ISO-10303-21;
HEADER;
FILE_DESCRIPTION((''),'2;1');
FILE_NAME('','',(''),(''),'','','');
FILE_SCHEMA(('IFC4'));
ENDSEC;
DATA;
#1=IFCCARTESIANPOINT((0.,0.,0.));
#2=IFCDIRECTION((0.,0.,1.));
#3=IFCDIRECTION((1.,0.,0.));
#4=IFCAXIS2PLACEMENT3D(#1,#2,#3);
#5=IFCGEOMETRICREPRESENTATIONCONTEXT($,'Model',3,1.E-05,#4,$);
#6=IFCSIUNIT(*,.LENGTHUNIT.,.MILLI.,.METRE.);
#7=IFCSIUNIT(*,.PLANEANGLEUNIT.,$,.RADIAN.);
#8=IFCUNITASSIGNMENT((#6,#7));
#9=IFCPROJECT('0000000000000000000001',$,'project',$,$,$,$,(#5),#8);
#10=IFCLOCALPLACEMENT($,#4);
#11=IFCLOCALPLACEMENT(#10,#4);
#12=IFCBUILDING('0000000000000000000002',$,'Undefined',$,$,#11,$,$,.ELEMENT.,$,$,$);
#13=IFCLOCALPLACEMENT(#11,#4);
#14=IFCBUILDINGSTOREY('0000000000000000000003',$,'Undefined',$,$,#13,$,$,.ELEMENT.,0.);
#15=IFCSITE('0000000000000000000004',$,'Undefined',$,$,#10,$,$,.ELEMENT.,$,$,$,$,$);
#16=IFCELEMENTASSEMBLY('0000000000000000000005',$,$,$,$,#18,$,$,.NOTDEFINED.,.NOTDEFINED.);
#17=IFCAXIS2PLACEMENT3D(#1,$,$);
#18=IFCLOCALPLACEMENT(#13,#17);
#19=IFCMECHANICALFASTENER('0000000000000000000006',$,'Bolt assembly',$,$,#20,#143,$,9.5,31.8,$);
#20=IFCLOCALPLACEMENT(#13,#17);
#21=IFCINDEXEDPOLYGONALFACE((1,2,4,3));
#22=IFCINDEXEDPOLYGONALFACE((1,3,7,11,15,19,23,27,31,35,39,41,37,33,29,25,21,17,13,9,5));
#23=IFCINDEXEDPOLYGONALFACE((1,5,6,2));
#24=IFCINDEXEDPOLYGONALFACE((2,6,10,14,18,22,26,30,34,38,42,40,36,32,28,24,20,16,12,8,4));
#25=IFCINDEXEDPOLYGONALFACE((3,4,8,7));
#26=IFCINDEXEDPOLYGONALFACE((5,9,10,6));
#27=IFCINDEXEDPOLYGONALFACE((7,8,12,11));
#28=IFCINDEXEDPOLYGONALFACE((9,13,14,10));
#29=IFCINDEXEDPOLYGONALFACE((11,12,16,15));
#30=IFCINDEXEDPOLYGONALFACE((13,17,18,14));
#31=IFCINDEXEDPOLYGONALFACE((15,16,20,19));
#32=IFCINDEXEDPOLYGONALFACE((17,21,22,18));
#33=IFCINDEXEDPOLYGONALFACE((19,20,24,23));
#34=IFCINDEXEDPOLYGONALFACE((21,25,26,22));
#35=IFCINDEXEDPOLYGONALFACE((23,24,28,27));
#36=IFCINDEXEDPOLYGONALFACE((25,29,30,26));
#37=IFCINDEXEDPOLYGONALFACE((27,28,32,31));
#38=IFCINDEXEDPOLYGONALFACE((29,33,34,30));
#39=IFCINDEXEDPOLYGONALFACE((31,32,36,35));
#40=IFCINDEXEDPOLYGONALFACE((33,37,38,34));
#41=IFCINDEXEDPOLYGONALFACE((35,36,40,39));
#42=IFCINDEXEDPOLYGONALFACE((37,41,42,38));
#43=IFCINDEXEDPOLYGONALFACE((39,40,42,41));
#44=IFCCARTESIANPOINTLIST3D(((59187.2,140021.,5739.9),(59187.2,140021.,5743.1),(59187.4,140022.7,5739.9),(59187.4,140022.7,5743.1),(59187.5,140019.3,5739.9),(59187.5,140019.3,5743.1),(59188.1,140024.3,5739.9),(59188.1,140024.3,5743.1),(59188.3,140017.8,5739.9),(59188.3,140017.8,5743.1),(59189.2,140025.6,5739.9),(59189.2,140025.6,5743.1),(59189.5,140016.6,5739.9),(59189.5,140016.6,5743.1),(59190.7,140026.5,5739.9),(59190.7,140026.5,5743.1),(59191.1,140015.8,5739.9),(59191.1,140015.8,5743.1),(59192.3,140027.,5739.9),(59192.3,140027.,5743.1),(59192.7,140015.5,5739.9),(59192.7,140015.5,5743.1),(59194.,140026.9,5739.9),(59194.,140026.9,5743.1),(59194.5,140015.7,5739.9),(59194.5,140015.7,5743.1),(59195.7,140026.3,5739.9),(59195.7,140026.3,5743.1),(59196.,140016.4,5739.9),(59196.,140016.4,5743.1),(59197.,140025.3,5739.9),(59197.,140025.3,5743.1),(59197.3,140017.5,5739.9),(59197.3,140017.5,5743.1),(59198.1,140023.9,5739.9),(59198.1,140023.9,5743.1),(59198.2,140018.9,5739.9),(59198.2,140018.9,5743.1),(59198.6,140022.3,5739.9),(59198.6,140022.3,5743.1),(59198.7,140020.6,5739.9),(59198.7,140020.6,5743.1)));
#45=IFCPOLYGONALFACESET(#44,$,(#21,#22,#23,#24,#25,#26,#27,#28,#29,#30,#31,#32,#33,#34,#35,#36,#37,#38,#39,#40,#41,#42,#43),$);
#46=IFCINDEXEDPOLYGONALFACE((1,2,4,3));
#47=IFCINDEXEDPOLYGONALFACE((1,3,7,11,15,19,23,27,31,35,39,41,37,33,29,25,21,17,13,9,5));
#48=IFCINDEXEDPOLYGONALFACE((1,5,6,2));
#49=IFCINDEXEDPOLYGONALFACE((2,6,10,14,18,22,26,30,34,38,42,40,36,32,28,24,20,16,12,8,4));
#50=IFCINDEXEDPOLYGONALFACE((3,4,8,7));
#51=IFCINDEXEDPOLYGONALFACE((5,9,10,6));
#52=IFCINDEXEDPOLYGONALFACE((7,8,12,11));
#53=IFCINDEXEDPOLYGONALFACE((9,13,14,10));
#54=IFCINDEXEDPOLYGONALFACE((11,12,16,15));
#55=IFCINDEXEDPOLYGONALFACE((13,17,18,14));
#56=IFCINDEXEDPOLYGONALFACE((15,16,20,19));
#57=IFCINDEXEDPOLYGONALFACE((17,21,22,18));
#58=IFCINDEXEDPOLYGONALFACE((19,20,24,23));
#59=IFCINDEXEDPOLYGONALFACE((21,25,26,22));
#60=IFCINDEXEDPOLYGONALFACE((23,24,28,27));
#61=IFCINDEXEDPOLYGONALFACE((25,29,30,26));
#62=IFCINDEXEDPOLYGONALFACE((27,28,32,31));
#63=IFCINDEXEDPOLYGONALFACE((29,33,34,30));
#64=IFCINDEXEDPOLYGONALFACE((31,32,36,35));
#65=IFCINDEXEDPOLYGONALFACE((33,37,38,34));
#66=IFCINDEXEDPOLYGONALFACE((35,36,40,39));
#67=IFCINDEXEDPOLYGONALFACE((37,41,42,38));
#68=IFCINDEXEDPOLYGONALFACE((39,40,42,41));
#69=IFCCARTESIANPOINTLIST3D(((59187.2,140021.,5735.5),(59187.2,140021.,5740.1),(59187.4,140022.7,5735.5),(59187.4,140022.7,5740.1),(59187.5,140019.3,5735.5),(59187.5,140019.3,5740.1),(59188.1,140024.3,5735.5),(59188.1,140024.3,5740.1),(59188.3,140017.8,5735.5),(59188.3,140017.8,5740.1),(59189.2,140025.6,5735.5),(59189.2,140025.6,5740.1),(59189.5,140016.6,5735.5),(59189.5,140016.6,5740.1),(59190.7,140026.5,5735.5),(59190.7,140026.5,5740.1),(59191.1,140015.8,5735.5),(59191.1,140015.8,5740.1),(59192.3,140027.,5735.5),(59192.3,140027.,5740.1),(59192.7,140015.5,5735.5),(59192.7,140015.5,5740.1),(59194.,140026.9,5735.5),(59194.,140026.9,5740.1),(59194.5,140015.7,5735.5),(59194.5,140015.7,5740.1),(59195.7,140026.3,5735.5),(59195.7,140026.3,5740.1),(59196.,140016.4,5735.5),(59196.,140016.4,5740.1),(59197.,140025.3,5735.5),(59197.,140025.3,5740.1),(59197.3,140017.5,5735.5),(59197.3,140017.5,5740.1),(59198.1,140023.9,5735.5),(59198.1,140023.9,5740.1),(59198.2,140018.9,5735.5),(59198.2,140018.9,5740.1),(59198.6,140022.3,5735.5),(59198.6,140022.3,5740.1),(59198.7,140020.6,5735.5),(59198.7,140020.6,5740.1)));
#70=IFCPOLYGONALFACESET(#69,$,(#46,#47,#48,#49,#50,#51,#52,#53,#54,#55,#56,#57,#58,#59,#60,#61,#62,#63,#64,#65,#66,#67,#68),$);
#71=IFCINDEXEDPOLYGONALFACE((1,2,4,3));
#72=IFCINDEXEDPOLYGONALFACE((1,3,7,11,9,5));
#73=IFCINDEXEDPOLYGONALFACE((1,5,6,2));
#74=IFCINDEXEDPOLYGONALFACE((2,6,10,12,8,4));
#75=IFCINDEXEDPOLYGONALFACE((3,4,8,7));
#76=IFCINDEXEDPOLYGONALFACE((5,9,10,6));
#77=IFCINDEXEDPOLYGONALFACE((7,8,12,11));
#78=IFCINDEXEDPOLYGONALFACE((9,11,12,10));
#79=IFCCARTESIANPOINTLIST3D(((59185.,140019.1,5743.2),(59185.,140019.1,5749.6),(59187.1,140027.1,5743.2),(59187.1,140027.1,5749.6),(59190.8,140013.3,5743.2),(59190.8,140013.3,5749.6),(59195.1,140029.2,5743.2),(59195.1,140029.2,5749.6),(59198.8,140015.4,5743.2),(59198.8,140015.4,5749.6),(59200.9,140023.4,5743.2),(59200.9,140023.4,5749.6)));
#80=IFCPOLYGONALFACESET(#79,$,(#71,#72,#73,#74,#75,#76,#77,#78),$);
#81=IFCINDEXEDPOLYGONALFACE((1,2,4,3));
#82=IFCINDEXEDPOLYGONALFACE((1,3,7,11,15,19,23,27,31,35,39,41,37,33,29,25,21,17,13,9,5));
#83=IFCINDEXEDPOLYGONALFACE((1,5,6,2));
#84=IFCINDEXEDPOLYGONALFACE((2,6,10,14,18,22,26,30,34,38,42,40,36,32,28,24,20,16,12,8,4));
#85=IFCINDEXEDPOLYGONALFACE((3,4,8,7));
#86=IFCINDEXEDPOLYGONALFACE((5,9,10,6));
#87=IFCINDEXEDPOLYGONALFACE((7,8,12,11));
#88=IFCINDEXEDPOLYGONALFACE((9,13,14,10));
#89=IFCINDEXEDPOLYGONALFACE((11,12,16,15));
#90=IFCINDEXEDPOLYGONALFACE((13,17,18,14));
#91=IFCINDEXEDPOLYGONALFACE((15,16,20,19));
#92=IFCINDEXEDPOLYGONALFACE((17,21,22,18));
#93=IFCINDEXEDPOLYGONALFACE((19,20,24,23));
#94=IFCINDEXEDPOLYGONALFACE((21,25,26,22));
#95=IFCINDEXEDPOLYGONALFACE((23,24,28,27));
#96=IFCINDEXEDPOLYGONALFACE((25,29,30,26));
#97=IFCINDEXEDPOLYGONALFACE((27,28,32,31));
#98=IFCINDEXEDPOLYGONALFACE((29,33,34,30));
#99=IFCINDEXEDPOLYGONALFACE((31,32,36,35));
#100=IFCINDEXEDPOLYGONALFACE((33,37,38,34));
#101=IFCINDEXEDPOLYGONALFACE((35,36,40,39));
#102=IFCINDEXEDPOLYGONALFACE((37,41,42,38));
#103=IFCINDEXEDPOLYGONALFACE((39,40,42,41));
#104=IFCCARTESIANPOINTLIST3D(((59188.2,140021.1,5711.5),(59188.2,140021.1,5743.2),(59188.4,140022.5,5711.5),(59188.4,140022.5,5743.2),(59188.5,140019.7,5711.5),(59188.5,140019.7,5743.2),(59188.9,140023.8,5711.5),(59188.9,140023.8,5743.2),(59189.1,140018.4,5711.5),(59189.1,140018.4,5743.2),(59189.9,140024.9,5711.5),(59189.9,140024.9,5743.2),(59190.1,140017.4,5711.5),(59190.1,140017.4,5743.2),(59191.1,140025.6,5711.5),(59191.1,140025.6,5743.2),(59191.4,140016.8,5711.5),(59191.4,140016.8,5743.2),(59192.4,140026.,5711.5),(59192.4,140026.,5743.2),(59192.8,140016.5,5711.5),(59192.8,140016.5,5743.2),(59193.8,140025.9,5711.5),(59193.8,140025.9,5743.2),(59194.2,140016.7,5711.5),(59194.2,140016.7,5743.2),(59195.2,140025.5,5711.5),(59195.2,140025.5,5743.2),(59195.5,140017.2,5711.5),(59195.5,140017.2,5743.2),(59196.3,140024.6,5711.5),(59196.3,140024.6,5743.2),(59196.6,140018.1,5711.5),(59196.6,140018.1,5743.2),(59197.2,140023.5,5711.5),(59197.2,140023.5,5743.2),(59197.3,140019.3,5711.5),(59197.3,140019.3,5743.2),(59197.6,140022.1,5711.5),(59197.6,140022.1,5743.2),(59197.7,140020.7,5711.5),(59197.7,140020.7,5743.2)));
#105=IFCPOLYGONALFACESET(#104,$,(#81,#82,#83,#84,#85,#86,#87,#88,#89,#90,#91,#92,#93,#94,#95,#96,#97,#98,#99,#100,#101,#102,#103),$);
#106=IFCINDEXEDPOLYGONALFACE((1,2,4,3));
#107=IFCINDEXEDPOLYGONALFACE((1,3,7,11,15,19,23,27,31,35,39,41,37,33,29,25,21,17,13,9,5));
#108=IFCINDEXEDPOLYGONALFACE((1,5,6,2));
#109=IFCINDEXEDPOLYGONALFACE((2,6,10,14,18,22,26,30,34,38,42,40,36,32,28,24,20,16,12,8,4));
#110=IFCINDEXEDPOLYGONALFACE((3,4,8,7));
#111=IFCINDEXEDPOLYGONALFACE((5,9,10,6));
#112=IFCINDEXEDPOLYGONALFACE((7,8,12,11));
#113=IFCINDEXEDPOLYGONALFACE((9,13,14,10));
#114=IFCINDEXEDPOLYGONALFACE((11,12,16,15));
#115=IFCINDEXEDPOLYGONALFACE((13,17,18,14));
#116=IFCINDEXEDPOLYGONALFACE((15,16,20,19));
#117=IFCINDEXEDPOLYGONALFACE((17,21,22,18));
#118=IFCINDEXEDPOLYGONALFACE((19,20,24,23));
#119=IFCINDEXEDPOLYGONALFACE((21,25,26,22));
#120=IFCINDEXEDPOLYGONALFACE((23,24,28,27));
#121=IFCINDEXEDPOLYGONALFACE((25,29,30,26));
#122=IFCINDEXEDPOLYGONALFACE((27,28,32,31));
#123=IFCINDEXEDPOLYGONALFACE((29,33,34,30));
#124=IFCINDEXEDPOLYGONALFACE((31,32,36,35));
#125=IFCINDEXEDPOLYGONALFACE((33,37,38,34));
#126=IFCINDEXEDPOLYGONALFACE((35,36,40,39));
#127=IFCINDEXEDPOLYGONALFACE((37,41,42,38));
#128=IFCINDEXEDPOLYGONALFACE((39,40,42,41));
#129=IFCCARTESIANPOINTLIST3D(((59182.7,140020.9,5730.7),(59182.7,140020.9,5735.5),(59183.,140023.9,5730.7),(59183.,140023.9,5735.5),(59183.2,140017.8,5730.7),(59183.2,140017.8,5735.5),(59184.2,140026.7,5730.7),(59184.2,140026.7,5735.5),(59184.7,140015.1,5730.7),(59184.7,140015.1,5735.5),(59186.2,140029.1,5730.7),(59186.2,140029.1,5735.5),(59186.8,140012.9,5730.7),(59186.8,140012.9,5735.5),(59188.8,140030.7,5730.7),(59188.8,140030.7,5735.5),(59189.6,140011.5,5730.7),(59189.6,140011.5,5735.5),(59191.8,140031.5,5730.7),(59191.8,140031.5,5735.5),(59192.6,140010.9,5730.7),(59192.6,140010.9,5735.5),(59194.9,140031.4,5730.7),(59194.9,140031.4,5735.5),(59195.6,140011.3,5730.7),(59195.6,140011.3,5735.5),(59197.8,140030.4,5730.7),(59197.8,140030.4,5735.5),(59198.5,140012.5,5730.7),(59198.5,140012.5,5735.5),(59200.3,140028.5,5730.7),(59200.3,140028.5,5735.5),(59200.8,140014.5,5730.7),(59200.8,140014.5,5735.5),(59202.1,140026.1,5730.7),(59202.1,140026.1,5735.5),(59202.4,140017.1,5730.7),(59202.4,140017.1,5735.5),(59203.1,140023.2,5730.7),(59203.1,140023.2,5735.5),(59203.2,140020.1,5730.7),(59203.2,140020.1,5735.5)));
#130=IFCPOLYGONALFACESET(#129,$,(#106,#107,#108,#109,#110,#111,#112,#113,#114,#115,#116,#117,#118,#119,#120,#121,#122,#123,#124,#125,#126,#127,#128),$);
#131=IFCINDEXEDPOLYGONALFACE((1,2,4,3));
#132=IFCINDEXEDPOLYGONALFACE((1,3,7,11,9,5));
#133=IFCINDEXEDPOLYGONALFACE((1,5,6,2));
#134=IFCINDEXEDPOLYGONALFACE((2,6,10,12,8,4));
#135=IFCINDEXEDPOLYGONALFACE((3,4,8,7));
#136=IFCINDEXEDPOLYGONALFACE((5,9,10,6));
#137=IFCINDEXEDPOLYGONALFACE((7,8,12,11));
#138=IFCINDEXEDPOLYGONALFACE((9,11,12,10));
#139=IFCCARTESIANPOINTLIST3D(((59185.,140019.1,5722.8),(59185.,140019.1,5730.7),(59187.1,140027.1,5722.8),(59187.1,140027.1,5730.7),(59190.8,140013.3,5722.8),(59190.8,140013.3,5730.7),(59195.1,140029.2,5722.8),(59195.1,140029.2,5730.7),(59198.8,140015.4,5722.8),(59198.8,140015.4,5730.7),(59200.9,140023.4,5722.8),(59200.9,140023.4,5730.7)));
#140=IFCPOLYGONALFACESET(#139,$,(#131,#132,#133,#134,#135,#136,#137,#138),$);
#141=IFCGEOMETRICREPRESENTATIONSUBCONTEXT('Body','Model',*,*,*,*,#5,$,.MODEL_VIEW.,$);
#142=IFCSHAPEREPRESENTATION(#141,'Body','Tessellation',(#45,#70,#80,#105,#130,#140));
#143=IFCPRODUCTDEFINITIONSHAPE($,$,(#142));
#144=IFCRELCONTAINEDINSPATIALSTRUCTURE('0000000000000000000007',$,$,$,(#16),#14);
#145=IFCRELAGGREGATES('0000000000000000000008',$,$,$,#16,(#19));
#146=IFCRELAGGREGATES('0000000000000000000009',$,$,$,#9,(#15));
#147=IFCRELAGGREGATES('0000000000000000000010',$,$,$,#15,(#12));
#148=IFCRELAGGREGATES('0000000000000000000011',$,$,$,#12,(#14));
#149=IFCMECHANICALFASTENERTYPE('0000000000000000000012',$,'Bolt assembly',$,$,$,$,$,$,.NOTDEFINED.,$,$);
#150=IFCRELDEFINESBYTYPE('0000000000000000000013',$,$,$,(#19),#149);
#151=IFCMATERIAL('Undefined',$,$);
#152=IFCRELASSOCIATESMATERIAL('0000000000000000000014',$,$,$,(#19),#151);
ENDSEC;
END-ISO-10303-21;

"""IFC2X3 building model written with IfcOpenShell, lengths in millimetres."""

from ifc_helpers import new_model, si_unit, frame, origin_with_axes, origin_2d_with_axis, place, context, subcontext, project, spatial, polyline, circle, outline, extrude, source, transform, mapped, material, type_object, element, aggregate, save


model = new_model("IFC2X3")

# Units and contexts
model_context = context("Model", 3, precision=1e-05, world=origin_with_axes())
body_context = subcontext(model_context, "Body", "Model", "MODEL_VIEW")
ifc_project = project(units=[si_unit("LENGTHUNIT", "METRE", prefix="MILLI"), si_unit("PLANEANGLEUNIT", "RADIAN")], contexts=[model_context])

# Site, building, storey
site_placement = place(None, origin_with_axes())
site = spatial("IfcSite", under=ifc_project, at=site_placement, Name="Undefined", CompositionType="ELEMENT")
building_placement = place(site_placement, origin_with_axes())
building = spatial("IfcBuilding", under=site, at=building_placement, Name="Undefined", CompositionType="ELEMENT")
storey_placement = place(building_placement, origin_with_axes())
storey = spatial("IfcBuildingStorey", under=building, at=storey_placement, Name="Undefined", CompositionType="ELEMENT", Elevation=0.0)

# Element assembly
assembly_1_placement = place(storey_placement, origin_with_axes())
assembly_1 = element("IfcElementAssembly", 1, at=assembly_1_placement, inside=storey, AssemblyPlace="NOTDEFINED", PredefinedType="NOTDEFINED")

# Mechanical fastener
ifc_material_1 = material(Name="Undefined")
mechanical_fastener_type = type_object("IfcMechanicalFastenerType", Name="Bolt assembly")
shared_shape_1 = source(origin_with_axes(), body_context, "Body", "SweptSolid", [
    extrude(circle(Radius=5.8, at=origin_2d_with_axis()), frame((0.0, -7.6, 0.0), z_axis=(0.0, 1.0, 0.0), x_axis=(1.0, 0.0, 0.0)), (0.0, 0.0, 1.0), 3.2),
    extrude(circle(Radius=5.8, at=origin_2d_with_axis()), frame((0.0, -4.6, 0.0), z_axis=(0.0, 1.0, 0.0), x_axis=(1.0, 0.0, 0.0)), (0.0, 0.0, 1.0), 4.6),
    extrude(outline(polyline([(7.1, -4.1), (7.1, 4.1), (0.0, 8.2), (-7.1, 4.1), (-7.1, -4.1), (0.0, -8.2), (7.1, -4.1)])), frame((0.0, -14.0, 0.0), z_axis=(0.0, 1.0, 0.0), x_axis=(1.0, 0.0, 0.0)), (0.0, 0.0, 1.0), 6.3),
    extrude(circle(Radius=4.8, at=origin_2d_with_axis()), frame((0.0, -7.7, 0.0), z_axis=(0.0, 1.0, 0.0), x_axis=(1.0, 0.0, 0.0)), (0.0, 0.0, 1.0), 31.8),
    extrude(circle(Radius=10.3, at=origin_2d_with_axis()), frame((0.0, 0.0, 0.0), z_axis=(0.0, 1.0, 0.0), x_axis=(1.0, 0.0, 0.0)), (0.0, 0.0, 1.0), 4.8),
    extrude(outline(polyline([(7.1, -4.1), (7.1, 4.1), (0.0, 8.2), (-7.1, 4.1), (-7.1, -4.1), (0.0, -8.2), (7.1, -4.1)])), frame((0.0, 4.8, 0.0), z_axis=(0.0, 1.0, 0.0), x_axis=(1.0, 0.0, 0.0)), (0.0, 0.0, 1.0), 7.9),
])
mechanical_fastener_1_placement = place(assembly_1_placement, frame((59193.0, 140021.3, 5735.5), z_axis=(-0.707107, 0.707107, 0.0), x_axis=(0.707107, 0.707107, 0.0)))
mechanical_fastener_1 = element("IfcMechanicalFastener", 2, at=mechanical_fastener_1_placement, type_object=mechanical_fastener_type, material=ifc_material_1, Name="Bolt assembly", NominalDiameter=9.5, NominalLength=31.8, context=body_context, shape_type="MappedRepresentation", body=[
    mapped(shared_shape_1, transform((0.0, 0.0, 0.0))),
])
aggregate(assembly_1, [mechanical_fastener_1])

save(model, "model.ifc")
